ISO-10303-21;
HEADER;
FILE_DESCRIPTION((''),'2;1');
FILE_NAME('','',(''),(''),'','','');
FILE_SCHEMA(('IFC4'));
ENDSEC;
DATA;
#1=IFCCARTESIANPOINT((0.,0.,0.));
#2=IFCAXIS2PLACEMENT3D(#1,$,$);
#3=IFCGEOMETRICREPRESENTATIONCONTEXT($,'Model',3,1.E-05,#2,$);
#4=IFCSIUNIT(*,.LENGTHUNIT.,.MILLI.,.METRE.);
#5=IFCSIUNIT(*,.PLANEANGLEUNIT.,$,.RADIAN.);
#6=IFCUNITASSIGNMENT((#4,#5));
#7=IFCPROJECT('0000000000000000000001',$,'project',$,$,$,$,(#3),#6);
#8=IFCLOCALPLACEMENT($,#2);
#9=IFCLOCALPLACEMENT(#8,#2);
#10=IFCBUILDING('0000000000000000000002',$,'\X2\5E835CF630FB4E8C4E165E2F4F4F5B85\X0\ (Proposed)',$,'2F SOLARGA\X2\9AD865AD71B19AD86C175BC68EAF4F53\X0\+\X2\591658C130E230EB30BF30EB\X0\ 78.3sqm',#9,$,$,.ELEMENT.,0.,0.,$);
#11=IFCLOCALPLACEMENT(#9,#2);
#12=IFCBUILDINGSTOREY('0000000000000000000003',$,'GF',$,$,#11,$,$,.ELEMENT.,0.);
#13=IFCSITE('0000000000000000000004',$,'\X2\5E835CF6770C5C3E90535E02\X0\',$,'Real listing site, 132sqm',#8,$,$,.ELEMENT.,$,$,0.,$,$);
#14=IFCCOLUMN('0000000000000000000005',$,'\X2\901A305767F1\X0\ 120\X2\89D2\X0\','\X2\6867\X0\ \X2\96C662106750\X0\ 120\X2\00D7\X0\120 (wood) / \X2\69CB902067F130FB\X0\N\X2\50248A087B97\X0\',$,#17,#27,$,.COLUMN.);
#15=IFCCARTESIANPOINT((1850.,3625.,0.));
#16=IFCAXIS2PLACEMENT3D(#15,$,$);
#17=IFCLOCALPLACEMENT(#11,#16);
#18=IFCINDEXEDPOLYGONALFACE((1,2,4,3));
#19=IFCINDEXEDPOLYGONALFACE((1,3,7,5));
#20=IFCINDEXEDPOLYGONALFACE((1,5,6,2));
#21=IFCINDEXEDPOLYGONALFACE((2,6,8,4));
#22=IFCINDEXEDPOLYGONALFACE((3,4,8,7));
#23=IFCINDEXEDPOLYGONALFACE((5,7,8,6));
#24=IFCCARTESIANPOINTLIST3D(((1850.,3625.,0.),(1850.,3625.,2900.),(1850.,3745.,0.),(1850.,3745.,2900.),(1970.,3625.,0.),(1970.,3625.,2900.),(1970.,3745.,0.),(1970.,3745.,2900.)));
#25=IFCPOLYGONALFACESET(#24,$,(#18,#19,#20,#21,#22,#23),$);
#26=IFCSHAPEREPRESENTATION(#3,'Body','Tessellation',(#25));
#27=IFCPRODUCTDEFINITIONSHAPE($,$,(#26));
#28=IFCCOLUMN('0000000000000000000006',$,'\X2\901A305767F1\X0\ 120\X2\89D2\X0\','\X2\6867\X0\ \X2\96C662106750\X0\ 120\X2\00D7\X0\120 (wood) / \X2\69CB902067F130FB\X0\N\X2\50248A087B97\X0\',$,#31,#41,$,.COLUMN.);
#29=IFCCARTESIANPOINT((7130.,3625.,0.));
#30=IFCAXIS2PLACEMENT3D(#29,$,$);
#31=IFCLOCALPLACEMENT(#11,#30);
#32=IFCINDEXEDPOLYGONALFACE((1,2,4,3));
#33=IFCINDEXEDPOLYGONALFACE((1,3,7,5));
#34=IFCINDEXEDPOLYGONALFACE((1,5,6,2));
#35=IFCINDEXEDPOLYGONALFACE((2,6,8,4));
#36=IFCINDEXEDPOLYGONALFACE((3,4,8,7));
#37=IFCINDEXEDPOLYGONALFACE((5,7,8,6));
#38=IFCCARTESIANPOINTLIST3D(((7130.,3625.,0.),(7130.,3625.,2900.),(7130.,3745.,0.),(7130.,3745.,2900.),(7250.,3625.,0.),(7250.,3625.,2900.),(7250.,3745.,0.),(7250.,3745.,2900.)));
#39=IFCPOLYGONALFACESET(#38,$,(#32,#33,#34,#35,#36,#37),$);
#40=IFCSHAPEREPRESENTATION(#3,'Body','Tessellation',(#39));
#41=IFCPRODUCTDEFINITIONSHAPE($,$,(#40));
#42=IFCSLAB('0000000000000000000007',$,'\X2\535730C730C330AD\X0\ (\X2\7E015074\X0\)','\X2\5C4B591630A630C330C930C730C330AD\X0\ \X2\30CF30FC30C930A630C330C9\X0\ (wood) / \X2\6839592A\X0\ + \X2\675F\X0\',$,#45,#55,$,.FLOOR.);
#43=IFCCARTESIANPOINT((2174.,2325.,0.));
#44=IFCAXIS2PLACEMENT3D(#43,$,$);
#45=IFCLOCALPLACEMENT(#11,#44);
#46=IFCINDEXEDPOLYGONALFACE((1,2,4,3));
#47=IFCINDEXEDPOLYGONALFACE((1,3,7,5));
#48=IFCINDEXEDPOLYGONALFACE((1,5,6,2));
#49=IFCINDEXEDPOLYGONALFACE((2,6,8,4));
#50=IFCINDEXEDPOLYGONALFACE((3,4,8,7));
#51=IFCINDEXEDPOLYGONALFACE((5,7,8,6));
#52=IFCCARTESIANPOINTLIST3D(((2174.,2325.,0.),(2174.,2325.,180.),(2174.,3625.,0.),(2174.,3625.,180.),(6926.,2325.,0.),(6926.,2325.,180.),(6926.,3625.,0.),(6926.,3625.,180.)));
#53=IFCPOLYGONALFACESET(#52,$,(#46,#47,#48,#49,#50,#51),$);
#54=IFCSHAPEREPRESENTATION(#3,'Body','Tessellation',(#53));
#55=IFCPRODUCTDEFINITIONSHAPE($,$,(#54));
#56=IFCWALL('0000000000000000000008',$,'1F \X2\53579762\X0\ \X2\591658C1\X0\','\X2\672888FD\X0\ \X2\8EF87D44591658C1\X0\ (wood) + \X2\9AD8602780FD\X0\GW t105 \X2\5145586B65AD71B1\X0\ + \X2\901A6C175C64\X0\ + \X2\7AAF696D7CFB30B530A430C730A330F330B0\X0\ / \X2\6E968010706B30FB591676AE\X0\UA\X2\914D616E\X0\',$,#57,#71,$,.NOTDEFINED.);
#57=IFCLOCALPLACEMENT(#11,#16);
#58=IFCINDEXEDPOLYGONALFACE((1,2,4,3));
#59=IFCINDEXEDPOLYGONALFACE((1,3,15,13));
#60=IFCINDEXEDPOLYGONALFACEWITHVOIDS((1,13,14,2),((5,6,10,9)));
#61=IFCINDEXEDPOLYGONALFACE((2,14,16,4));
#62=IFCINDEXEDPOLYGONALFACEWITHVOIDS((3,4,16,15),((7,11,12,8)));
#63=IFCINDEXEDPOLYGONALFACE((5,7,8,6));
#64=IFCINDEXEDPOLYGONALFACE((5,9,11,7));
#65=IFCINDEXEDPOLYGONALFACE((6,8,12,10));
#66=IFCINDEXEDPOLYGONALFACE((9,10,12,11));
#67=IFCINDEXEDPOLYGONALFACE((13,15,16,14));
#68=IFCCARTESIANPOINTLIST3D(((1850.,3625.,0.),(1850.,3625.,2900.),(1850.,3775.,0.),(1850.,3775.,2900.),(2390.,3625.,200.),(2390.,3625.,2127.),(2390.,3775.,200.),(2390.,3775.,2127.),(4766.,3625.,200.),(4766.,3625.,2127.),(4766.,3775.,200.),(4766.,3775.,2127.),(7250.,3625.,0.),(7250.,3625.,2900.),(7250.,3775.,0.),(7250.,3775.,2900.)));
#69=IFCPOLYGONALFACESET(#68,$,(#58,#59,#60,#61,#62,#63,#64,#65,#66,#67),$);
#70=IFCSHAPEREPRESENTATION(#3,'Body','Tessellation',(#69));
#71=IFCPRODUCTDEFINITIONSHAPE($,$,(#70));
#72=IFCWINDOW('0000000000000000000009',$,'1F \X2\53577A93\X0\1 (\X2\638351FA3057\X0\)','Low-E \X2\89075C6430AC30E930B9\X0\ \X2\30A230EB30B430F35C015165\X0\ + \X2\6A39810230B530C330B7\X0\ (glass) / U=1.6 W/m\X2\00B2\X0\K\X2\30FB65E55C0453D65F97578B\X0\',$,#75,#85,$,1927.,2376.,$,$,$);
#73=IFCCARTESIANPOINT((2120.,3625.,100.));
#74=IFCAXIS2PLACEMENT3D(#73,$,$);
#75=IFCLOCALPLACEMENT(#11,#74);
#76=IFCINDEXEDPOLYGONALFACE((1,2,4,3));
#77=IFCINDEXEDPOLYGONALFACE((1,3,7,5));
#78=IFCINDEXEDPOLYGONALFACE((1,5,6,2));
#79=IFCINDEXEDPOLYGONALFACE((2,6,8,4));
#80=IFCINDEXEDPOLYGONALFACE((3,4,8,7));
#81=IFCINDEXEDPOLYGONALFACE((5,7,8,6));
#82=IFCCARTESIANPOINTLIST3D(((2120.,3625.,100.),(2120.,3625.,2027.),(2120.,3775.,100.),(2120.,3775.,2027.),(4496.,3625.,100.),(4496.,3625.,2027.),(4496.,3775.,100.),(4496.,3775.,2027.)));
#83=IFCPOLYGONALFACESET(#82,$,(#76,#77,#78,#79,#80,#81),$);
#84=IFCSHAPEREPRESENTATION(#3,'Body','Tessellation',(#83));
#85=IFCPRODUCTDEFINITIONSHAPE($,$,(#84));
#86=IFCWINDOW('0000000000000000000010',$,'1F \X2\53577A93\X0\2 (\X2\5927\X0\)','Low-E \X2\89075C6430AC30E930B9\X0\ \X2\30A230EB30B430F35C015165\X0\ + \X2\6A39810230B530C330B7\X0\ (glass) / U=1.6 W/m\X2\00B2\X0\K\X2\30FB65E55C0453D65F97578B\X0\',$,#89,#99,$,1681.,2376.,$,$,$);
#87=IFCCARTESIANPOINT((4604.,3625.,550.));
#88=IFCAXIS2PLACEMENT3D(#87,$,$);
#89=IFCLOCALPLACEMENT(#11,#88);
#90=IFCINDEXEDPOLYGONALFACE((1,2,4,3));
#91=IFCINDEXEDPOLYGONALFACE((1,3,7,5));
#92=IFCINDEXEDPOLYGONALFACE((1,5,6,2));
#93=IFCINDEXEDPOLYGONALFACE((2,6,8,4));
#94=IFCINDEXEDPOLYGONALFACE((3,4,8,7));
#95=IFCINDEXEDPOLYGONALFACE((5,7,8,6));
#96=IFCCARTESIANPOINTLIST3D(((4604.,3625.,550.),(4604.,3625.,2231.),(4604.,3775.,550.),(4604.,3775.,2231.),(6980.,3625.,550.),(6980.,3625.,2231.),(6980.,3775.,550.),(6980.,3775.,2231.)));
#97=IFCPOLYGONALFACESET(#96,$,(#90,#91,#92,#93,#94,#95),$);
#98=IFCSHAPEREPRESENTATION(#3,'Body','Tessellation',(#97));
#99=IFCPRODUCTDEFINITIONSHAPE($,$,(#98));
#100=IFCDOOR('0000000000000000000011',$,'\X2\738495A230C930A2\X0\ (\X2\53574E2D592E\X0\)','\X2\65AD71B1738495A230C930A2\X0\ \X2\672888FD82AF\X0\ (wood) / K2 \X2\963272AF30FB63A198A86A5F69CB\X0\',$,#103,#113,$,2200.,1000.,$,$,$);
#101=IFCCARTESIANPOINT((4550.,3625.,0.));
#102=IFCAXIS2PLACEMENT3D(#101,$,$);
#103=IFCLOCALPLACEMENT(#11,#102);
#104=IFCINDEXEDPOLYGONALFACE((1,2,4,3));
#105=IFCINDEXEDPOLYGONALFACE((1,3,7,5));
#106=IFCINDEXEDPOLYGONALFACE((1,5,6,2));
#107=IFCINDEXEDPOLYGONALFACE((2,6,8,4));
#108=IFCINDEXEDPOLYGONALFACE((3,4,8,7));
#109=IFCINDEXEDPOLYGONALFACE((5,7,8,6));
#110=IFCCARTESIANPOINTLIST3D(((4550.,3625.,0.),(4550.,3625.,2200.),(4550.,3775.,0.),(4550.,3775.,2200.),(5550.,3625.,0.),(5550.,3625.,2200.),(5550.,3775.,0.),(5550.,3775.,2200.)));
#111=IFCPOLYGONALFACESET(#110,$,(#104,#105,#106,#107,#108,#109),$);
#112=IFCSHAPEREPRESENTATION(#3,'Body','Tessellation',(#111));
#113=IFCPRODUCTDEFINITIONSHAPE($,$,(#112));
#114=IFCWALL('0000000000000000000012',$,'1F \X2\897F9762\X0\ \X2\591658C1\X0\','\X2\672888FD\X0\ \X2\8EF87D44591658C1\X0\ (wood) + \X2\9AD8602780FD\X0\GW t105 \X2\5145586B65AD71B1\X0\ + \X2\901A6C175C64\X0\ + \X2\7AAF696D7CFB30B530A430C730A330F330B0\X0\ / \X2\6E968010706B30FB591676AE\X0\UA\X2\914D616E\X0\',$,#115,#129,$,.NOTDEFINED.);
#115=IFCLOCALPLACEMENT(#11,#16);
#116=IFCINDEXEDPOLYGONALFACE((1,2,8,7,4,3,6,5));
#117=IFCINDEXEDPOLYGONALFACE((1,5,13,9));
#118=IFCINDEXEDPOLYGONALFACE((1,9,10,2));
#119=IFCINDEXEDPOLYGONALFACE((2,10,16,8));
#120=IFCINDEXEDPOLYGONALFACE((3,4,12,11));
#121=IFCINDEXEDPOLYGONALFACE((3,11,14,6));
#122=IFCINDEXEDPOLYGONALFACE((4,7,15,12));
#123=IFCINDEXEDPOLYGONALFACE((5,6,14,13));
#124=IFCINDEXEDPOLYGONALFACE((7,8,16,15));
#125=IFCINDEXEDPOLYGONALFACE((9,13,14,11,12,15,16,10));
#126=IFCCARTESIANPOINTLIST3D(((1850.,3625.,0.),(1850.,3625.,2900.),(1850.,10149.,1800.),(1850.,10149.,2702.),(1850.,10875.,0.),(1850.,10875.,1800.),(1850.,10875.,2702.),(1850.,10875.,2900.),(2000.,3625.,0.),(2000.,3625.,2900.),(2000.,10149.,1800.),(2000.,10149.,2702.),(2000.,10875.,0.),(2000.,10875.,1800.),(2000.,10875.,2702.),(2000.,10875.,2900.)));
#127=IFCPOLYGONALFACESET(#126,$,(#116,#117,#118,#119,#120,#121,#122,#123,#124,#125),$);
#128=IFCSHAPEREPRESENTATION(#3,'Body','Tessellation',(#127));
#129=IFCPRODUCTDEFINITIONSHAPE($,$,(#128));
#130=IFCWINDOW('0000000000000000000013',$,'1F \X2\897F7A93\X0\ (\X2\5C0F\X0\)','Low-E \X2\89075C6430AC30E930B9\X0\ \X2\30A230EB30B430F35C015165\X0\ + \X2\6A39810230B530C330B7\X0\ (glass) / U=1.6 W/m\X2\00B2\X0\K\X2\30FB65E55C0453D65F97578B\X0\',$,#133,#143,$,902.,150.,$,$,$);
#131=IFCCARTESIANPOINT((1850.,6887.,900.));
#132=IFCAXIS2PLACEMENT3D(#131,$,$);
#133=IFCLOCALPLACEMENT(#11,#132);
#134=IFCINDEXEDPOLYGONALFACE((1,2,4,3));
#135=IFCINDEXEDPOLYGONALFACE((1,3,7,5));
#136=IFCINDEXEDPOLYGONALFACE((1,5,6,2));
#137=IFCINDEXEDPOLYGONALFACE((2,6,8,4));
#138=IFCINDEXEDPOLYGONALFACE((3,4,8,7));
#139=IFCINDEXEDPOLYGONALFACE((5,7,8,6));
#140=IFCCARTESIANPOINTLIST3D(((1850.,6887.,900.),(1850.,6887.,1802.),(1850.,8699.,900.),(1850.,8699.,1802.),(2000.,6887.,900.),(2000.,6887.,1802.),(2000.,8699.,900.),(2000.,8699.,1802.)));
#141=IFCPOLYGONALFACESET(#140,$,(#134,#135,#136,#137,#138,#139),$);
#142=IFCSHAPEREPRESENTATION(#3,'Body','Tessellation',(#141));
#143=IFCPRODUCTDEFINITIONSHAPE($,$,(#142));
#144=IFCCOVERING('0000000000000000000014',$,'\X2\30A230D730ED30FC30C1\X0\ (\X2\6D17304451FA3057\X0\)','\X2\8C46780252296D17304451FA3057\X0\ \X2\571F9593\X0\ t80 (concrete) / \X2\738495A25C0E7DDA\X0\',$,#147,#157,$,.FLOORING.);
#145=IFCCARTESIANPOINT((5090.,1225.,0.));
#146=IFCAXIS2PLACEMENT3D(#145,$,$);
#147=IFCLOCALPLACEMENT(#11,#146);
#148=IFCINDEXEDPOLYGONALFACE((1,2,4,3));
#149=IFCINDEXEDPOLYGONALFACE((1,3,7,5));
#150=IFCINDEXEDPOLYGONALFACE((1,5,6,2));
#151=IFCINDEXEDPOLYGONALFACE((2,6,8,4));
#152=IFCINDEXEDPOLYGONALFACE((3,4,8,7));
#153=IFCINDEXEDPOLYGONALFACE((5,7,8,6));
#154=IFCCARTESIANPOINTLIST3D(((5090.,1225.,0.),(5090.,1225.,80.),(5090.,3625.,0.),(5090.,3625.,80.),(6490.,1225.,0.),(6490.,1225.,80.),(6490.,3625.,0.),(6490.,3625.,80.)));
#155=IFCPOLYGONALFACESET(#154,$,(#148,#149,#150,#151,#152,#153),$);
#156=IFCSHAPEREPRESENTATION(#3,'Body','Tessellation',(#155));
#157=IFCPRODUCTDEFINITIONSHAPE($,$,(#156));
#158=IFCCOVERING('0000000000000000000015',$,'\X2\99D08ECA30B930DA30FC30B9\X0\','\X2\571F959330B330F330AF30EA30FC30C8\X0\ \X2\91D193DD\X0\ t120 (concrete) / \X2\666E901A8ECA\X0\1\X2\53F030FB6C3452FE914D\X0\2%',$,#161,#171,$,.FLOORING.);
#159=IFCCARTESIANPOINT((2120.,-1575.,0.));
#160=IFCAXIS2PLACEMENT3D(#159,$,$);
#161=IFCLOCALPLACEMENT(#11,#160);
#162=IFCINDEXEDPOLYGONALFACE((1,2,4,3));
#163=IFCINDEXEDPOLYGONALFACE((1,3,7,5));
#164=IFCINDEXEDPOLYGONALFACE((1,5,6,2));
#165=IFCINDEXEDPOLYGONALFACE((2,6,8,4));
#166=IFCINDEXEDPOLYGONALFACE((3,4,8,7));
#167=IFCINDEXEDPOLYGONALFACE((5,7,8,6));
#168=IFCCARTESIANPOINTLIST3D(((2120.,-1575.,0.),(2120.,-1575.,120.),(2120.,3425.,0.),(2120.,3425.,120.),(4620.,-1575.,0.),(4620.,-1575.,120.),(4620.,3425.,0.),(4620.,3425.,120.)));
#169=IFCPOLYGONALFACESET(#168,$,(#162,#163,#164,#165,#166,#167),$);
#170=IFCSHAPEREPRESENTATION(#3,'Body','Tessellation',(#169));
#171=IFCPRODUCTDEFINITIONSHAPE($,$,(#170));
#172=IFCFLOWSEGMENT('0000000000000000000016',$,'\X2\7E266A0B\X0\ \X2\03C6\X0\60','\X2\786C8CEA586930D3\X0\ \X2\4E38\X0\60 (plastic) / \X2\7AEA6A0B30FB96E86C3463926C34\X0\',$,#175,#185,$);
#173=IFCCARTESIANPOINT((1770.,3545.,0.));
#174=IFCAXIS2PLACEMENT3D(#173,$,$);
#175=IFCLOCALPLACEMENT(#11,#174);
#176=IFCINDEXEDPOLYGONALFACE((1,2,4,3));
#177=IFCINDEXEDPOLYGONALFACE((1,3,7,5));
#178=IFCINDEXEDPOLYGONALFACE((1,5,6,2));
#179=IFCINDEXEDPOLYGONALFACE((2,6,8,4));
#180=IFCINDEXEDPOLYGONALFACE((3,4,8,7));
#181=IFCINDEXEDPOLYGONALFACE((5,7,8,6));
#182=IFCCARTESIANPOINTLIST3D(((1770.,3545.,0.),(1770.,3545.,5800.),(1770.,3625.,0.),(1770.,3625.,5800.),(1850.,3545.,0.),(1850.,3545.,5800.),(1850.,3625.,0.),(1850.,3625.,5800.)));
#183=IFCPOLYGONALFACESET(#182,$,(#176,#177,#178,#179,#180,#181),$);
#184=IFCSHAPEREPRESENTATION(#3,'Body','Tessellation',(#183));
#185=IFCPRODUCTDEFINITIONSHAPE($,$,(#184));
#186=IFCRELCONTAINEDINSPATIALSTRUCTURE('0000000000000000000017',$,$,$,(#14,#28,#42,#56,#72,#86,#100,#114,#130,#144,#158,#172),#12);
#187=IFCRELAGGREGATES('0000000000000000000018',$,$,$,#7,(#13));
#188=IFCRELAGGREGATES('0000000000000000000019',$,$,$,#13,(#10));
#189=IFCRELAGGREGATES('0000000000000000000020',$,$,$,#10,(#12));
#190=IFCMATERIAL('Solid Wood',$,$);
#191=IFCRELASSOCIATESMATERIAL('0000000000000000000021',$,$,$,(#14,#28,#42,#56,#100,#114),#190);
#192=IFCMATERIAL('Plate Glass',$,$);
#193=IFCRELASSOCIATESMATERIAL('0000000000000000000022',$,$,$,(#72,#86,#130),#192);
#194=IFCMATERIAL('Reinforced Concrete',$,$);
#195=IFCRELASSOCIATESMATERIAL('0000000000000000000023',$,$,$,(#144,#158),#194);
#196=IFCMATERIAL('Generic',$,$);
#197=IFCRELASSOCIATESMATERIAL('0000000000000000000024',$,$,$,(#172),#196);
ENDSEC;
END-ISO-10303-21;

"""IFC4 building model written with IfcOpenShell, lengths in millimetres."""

from ifc_helpers import new_model, si_unit, frame, frame_2d, origin, place, context, project, spatial, rectangle, extrude, material, element, fill, save


model = new_model("IFC4")

# Units and contexts
model_context = context("Model", 3, precision=1e-05, world=origin())
ifc_project = project(units=[si_unit("LENGTHUNIT", "METRE", prefix="MILLI"), si_unit("PLANEANGLEUNIT", "RADIAN")], contexts=[model_context])

# Site, building, storey
site_placement = place(None, origin())
site = spatial("IfcSite", under=ifc_project, at=site_placement, Name="広島県尾道市", ObjectType="Real listing site, 132sqm", CompositionType="ELEMENT", RefElevation=0.0)
building_placement = place(site_placement, origin())
building = spatial("IfcBuilding", under=site, at=building_placement, Name="広島・二世帯住宅 (Proposed)", ObjectType="2F SOLARGA高断熱高気密躯体+外壁モルタル 78.3sqm", CompositionType="ELEMENT", ElevationOfRefHeight=0.0, ElevationOfTerrain=0.0)
storey_placement = place(building_placement, origin())
storey = spatial("IfcBuildingStorey", under=building, at=storey_placement, Name="GF", CompositionType="ELEMENT", Elevation=0.0)

# Columns
ifc_material_1 = material(Name="Solid Wood")
column_1_placement = place(storey_placement, frame((1850.0, 3625.0, 0.0)))
element("IfcColumn", 1, at=column_1_placement, inside=storey, material=ifc_material_1, Name="通し柱 120角", Description="桧 集成材 120×120 (wood) / 構造柱・N値計算", PredefinedType="COLUMN", context=model_context, shape_type="SweptSolid", body=[
    extrude(rectangle(XDim=120.0, YDim=120.0, at=frame_2d((60.0, 60.0))), frame((1850.0, 3625.0, 0.0)), (0.0, 0.0, 1.0), 2900.0),
])
column_2_placement = place(storey_placement, frame((7130.0, 3625.0, 0.0)))
element("IfcColumn", 2, at=column_2_placement, inside=storey, material=ifc_material_1, Name="通し柱 120角", Description="桧 集成材 120×120 (wood) / 構造柱・N値計算", PredefinedType="COLUMN", context=model_context, shape_type="SweptSolid", body=[
    extrude(rectangle(XDim=120.0, YDim=120.0, at=frame_2d((60.0, 60.0))), frame((7130.0, 3625.0, 0.0)), (0.0, 0.0, 1.0), 2900.0),
])

# Slab
ifc_material_2 = material(Name="Reinforced Concrete")
slab_1_placement = place(storey_placement, frame((2174.0, 2325.0, 0.0)))
element("IfcSlab", 3, at=slab_1_placement, inside=storey, material=ifc_material_1, Name="南デッキ (縁側)", Description="屋外ウッドデッキ ハードウッド (wood) / 根太 + 束", PredefinedType="FLOOR", context=model_context, shape_type="SweptSolid", body=[
    extrude(rectangle(XDim=4752.0, YDim=1300.0, at=frame_2d((2376.0, 650.0))), frame((2174.0, 2325.0, 0.0)), (0.0, 0.0, 1.0), 180.0),
])

# Wall, openings, windows, door
wall_1_placement = place(storey_placement, frame((1850.0, 3625.0, 0.0)))
wall_1 = element("IfcWall", 4, at=wall_1_placement, inside=storey, material=ifc_material_1, Name="1F 南面 外壁", Description="木製 軸組外壁 (wood) + 高性能GW t105 充填断熱 + 通気層 + 窯業系サイディング / 準耐火・外皮UA配慮", PredefinedType="NOTDEFINED", context=model_context, shape_type="SweptSolid", body=[
    extrude(rectangle(XDim=5400.0, YDim=150.0, at=frame_2d((2700.0, 75.0))), frame((1850.0, 3625.0, 0.0)), (0.0, 0.0, 1.0), 2900.0),
])
opening_1_placement = place(storey_placement, frame((2120.0, 3625.0, 100.0)))
opening_1 = element("IfcOpeningElement", 5, at=opening_1_placement, cuts=wall_1, PredefinedType="NOTDEFINED", context=model_context, shape_type="SweptSolid", body=[
    extrude(rectangle(XDim=2376.0, YDim=150.0, at=frame_2d((1188.0, 75.0))), frame((2120.0, 3625.0, 100.0)), (0.0, 0.0, 1.0), 1927.0),
])
opening_2_placement = place(storey_placement, frame((4604.0, 3625.0, 550.0)))
opening_2 = element("IfcOpeningElement", 6, at=opening_2_placement, cuts=wall_1, PredefinedType="NOTDEFINED", context=model_context, shape_type="SweptSolid", body=[
    extrude(rectangle(XDim=2376.0, YDim=150.0, at=frame_2d((1188.0, 75.0))), frame((4604.0, 3625.0, 550.0)), (0.0, 0.0, 1.0), 1681.0),
])
opening_3_placement = place(storey_placement, frame((4550.0, 3625.0, 0.0)))
opening_3 = element("IfcOpeningElement", 7, at=opening_3_placement, cuts=wall_1, PredefinedType="NOTDEFINED", context=model_context, shape_type="SweptSolid", body=[
    extrude(rectangle(XDim=1000.0, YDim=150.0, at=frame_2d((500.0, 75.0))), frame((4550.0, 3625.0, 0.0)), (0.0, 0.0, 1.0), 2200.0),
])
ifc_material_3 = material(Name="Plate Glass")
window_1_placement = place(storey_placement, frame((2120.0, 3625.0, 100.0)))
window_1 = element("IfcWindow", 8, at=window_1_placement, inside=storey, material=ifc_material_3, Name="1F 南窓1 (掃出し)", Description="Low-E 複層ガラス アルゴン封入 + 樹脂サッシ (glass) / U=1.6 W/m²K・日射取得型", OverallHeight=1927.0, OverallWidth=2376.0, context=model_context, shape_type="SweptSolid", body=[
    extrude(rectangle(XDim=2376.0, YDim=150.0, at=frame_2d((1188.0, 75.0))), frame((2120.0, 3625.0, 100.0)), (0.0, 0.0, 1.0), 1927.0),
])
fill(opening_1, window_1)
window_2_placement = place(storey_placement, frame((4604.0, 3625.0, 550.0)))
window_2 = element("IfcWindow", 9, at=window_2_placement, inside=storey, material=ifc_material_3, Name="1F 南窓2 (大)", Description="Low-E 複層ガラス アルゴン封入 + 樹脂サッシ (glass) / U=1.6 W/m²K・日射取得型", OverallHeight=1681.0, OverallWidth=2376.0, context=model_context, shape_type="SweptSolid", body=[
    extrude(rectangle(XDim=2376.0, YDim=150.0, at=frame_2d((1188.0, 75.0))), frame((4604.0, 3625.0, 550.0)), (0.0, 0.0, 1.0), 1681.0),
])
fill(opening_2, window_2)
door_placement = place(storey_placement, frame((4550.0, 3625.0, 0.0)))
door = element("IfcDoor", 10, at=door_placement, inside=storey, material=ifc_material_1, Name="玄関ドア (南中央)", Description="断熱玄関ドア 木製芯 (wood) / K2 防犯・採風機構", OverallHeight=2200.0, OverallWidth=1000.0, context=model_context, shape_type="SweptSolid", body=[
    extrude(rectangle(XDim=1000.0, YDim=150.0, at=frame_2d((500.0, 75.0))), frame((4550.0, 3625.0, 0.0)), (0.0, 0.0, 1.0), 2200.0),
])
fill(opening_3, door)

# Wall, opening, window
wall_2_placement = place(storey_placement, frame((1850.0, 3625.0, 0.0)))
wall_2 = element("IfcWall", 11, at=wall_2_placement, inside=storey, material=ifc_material_1, Name="1F 西面 外壁", Description="木製 軸組外壁 (wood) + 高性能GW t105 充填断熱 + 通気層 + 窯業系サイディング / 準耐火・外皮UA配慮", PredefinedType="NOTDEFINED", context=model_context, shape_type="SweptSolid", body=[
    extrude(rectangle(XDim=150.0, YDim=7250.0, at=frame_2d((75.0, 3625.0))), frame((1850.0, 3625.0, 0.0)), (0.0, 0.0, 1.0), 2900.0),
])
opening_4_placement = place(storey_placement, frame((1850.0, 6887.0, 900.0)))
opening_4 = element("IfcOpeningElement", 12, at=opening_4_placement, cuts=wall_2, PredefinedType="NOTDEFINED", context=model_context, shape_type="SweptSolid", body=[
    extrude(rectangle(XDim=150.0, YDim=1812.0, at=frame_2d((75.0, 906.0))), frame((1850.0, 6887.0, 900.0)), (0.0, 0.0, 1.0), 902.0),
])
window_3_placement = place(storey_placement, frame((1850.0, 6887.0, 900.0)))
window_3 = element("IfcWindow", 13, at=window_3_placement, inside=storey, material=ifc_material_3, Name="1F 西窓 (小)", Description="Low-E 複層ガラス アルゴン封入 + 樹脂サッシ (glass) / U=1.6 W/m²K・日射取得型", OverallHeight=902.0, OverallWidth=150.0, context=model_context, shape_type="SweptSolid", body=[
    extrude(rectangle(XDim=150.0, YDim=1812.0, at=frame_2d((75.0, 906.0))), frame((1850.0, 6887.0, 900.0)), (0.0, 0.0, 1.0), 902.0),
])
fill(opening_4, window_3)

# Coverings
covering_1_placement = place(storey_placement, frame((5090.0, 1225.0, 0.0)))
element("IfcCovering", 14, at=covering_1_placement, inside=storey, material=ifc_material_2, Name="アプローチ (洗い出し)", Description="豆砂利洗い出し 土間 t80 (concrete) / 玄関導線", PredefinedType="FLOORING", context=model_context, shape_type="SweptSolid", body=[
    extrude(rectangle(XDim=1400.0, YDim=2400.0, at=frame_2d((700.0, 1200.0))), frame((5090.0, 1225.0, 0.0)), (0.0, 0.0, 1.0), 80.0),
])
covering_2_placement = place(storey_placement, frame((2120.0, -1575.0, 0.0)))
element("IfcCovering", 15, at=covering_2_placement, inside=storey, material=ifc_material_2, Name="駐車スペース", Description="土間コンクリート 金鏝 t120 (concrete) / 普通車1台・水勾配2%", PredefinedType="FLOORING", context=model_context, shape_type="SweptSolid", body=[
    extrude(rectangle(XDim=2500.0, YDim=5000.0, at=frame_2d((1250.0, 2500.0))), frame((2120.0, -1575.0, 0.0)), (0.0, 0.0, 1.0), 120.0),
])

# Flow segment
ifc_material_4 = material(Name="Generic")
flow_segment_1_placement = place(storey_placement, frame((1770.0, 3545.0, 0.0)))
element("IfcFlowSegment", 16, at=flow_segment_1_placement, inside=storey, material=ifc_material_4, Name="縦樋 φ60", Description="硬質塩ビ 丸60 (plastic) / 竪樋・雨水排水", context=model_context, shape_type="SweptSolid", body=[
    extrude(rectangle(XDim=80.0, YDim=80.0, at=frame_2d((40.0, 40.0))), frame((1770.0, 3545.0, 0.0)), (0.0, 0.0, 1.0), 5800.0),
])

save(model, "model.ifc")
